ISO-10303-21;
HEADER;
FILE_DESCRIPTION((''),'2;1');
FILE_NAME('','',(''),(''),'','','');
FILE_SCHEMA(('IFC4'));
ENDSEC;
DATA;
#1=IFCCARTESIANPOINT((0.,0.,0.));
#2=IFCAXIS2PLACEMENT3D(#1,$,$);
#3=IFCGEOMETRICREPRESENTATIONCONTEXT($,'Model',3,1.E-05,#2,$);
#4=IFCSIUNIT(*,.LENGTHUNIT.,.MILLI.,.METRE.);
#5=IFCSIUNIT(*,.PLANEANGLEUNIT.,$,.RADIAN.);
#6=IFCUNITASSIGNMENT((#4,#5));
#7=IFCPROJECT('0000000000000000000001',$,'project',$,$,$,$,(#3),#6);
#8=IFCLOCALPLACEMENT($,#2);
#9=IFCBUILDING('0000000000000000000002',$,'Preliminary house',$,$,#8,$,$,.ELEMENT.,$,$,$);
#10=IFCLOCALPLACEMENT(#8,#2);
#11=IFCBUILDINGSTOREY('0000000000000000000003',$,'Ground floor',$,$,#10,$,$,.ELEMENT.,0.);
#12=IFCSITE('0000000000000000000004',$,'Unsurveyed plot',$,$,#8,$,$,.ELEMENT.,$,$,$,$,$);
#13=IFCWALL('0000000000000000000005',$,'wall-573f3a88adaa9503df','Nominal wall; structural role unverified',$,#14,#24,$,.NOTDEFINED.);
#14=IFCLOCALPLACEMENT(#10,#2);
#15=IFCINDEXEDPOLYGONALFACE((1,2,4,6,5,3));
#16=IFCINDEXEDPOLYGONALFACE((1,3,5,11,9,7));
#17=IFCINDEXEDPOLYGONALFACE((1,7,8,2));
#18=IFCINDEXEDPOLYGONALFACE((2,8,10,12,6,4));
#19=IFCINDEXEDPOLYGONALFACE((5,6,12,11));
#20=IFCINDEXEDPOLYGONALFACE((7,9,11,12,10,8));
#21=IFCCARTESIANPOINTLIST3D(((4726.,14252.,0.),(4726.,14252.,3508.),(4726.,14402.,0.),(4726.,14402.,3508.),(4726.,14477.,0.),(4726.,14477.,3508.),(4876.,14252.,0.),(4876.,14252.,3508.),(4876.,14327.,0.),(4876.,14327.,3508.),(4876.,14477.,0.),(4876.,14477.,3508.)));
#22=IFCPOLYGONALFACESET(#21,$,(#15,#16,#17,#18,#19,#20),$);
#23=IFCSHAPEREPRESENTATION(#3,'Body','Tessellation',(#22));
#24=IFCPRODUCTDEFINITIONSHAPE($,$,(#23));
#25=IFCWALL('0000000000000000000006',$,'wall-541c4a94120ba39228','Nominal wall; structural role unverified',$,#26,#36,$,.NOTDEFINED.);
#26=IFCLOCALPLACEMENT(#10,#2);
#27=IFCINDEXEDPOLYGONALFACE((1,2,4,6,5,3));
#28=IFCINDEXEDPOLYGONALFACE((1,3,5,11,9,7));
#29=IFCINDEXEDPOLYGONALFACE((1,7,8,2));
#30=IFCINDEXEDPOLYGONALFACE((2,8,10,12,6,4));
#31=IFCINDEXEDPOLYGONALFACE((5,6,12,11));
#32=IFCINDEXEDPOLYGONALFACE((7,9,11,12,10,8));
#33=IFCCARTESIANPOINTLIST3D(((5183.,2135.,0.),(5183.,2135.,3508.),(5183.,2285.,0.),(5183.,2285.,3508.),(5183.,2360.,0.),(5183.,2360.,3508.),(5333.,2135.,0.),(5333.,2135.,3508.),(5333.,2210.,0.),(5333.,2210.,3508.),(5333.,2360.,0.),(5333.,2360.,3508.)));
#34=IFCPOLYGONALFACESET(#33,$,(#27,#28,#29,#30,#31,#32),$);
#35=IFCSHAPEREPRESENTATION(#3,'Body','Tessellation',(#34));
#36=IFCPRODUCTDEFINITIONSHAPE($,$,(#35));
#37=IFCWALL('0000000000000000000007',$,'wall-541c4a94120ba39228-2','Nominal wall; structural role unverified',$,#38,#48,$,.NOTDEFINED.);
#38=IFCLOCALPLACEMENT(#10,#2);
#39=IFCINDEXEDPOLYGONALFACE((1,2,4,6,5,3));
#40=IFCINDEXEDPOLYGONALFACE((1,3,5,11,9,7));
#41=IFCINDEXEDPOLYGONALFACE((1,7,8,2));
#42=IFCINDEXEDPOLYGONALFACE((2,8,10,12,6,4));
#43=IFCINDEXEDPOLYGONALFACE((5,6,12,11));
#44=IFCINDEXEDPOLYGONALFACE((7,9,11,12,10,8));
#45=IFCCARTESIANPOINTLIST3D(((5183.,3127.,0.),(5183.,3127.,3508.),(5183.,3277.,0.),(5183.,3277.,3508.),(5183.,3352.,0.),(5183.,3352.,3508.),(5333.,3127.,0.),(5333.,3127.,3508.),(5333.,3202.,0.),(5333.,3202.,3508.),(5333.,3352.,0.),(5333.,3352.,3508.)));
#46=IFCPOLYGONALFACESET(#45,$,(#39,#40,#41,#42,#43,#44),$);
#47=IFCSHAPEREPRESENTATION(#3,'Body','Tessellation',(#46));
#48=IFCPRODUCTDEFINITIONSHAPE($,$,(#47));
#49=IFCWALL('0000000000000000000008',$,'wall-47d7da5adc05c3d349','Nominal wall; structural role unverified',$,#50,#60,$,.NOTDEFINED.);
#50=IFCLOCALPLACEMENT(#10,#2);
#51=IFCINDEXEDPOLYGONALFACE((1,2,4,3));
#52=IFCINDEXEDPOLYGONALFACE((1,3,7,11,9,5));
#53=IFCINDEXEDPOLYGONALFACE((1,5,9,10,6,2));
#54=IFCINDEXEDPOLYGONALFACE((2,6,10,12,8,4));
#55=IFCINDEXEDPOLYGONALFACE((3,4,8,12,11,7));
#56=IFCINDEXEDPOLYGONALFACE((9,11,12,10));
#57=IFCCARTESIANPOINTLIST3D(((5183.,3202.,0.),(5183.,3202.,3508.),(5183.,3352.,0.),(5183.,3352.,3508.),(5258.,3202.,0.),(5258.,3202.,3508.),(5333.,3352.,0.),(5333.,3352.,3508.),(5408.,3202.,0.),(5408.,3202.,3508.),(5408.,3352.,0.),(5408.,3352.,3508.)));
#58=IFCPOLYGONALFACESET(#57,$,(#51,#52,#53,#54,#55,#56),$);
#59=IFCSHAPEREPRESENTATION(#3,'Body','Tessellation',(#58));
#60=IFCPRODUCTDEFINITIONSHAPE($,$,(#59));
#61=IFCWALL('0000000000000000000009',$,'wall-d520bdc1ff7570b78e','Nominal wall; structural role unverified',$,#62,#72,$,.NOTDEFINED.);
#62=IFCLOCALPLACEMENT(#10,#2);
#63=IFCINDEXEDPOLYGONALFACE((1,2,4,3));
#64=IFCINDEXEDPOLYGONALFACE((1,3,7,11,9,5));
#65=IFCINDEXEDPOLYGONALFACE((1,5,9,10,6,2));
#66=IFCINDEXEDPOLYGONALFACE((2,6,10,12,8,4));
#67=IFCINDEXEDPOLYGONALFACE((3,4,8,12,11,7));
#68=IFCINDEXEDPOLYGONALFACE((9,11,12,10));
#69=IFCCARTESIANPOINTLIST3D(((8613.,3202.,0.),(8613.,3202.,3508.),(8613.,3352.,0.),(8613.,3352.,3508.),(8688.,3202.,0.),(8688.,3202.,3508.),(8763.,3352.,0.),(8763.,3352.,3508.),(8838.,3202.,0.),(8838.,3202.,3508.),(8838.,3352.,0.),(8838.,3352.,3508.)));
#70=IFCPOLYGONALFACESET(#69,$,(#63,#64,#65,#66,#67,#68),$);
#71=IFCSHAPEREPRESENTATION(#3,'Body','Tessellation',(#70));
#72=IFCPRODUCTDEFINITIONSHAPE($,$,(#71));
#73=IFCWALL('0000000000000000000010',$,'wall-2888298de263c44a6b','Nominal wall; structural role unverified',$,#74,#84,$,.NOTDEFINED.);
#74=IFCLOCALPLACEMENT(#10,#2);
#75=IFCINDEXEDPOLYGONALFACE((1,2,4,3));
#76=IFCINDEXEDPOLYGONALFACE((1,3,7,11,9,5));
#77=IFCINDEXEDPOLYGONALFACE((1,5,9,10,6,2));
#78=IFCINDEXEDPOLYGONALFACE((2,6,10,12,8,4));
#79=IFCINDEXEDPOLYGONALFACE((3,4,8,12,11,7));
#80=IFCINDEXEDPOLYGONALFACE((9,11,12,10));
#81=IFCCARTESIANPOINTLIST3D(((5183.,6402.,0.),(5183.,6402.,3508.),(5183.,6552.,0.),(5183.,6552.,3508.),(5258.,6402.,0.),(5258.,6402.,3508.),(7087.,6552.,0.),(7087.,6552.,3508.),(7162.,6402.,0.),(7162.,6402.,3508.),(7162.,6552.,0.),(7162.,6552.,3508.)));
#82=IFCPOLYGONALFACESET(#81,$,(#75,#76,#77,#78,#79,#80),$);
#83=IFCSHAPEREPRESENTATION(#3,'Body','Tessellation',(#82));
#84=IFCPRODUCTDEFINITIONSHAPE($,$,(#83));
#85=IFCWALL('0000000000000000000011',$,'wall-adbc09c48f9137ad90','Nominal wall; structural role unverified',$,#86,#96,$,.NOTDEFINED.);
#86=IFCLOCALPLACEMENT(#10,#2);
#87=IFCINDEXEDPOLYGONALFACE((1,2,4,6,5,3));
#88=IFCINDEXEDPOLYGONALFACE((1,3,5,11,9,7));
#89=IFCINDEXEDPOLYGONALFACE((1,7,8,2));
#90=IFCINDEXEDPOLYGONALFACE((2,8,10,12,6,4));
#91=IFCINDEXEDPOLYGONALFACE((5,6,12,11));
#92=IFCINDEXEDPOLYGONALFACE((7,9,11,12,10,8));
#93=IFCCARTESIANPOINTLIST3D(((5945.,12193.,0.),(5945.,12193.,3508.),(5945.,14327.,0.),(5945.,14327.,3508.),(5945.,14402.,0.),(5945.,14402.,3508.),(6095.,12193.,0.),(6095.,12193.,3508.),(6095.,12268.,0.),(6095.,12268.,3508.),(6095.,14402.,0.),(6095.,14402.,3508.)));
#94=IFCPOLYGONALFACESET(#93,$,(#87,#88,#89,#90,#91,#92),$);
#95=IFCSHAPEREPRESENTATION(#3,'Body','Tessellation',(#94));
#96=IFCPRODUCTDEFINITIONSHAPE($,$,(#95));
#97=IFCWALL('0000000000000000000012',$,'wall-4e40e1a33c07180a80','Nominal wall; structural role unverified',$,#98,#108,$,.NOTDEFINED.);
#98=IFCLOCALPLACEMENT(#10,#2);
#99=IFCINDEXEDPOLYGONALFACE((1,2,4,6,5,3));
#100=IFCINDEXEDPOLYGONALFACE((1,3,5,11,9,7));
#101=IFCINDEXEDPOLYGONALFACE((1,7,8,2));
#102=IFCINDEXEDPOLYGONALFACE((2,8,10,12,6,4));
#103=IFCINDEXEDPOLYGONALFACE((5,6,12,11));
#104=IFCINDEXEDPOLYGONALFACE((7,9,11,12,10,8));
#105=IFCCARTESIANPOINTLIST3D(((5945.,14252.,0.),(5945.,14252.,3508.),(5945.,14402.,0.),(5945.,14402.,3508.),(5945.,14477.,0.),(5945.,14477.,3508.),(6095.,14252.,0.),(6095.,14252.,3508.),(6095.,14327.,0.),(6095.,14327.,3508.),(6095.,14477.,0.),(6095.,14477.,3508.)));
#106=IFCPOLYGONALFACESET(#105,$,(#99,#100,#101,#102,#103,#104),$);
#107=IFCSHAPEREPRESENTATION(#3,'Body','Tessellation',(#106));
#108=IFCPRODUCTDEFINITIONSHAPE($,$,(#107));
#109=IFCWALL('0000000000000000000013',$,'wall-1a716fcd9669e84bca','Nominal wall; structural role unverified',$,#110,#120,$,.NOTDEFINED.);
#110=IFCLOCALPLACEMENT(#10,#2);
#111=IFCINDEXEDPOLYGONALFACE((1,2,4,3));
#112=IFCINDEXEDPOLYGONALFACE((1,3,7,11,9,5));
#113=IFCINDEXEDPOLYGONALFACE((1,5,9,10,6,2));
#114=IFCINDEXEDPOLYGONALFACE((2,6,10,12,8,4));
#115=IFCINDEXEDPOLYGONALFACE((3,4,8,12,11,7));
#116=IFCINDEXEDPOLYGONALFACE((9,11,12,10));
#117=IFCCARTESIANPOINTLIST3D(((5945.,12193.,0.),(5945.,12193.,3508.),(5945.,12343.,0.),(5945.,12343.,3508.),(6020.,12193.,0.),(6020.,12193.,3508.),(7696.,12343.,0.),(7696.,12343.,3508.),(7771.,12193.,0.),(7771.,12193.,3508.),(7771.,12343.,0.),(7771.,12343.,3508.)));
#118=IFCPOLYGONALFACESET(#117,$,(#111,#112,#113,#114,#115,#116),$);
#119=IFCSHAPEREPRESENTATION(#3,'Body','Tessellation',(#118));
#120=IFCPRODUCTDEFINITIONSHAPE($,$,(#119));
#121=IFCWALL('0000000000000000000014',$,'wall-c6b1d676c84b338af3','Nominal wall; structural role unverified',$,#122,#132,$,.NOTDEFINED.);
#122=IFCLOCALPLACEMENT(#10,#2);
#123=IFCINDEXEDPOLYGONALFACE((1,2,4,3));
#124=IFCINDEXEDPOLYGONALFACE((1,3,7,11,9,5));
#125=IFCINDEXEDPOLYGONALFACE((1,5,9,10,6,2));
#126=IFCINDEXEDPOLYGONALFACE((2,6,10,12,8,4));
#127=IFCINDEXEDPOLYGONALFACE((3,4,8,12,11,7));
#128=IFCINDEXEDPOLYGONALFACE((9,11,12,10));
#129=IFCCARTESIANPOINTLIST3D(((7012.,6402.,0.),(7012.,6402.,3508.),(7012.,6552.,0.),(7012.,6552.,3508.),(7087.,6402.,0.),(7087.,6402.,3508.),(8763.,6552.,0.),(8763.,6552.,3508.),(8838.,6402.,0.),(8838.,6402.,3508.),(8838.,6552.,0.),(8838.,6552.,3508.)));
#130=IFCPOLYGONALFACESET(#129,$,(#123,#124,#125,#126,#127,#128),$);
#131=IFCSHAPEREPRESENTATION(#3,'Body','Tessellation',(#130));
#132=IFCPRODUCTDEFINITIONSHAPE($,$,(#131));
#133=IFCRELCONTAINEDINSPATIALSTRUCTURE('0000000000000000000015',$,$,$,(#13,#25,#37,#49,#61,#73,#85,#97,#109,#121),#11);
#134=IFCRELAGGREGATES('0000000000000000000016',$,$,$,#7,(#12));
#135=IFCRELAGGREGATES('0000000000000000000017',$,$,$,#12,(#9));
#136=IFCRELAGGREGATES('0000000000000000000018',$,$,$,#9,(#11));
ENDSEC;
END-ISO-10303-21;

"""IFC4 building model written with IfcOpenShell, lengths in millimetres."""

from ifc_helpers import new_model, si_unit, origin, place, context, project, spatial, polyline, outline, extrude, element, save


model = new_model("IFC4")

# Units and contexts
model_context = context("Model", 3, precision=1e-05, world=origin())
ifc_project = project(units=[si_unit("LENGTHUNIT", "METRE", prefix="MILLI"), si_unit("PLANEANGLEUNIT", "RADIAN")], contexts=[model_context])

# Site, building, storey
placement_1 = place(None, origin())
site = spatial("IfcSite", under=ifc_project, at=placement_1, Name="Unsurveyed plot", CompositionType="ELEMENT")
building = spatial("IfcBuilding", under=site, at=placement_1, Name="Preliminary house", CompositionType="ELEMENT")
placement_2 = place(placement_1, origin())
storey = spatial("IfcBuildingStorey", under=building, at=placement_2, Name="Ground floor", CompositionType="ELEMENT", Elevation=0.0)

# Walls
element("IfcWall", 1, at=placement_2, inside=storey, Name="wall-573f3a88adaa9503df", Description="Nominal wall; structural role unverified", PredefinedType="NOTDEFINED", context=model_context, shape_type="SweptSolid", body=[
    extrude(outline(polyline([(4726.0, 14402.0), (4726.0, 14477.0), (4876.0, 14477.0), (4876.0, 14327.0), (4876.0, 14252.0), (4726.0, 14252.0), (4726.0, 14402.0)])), origin(), (0.0, 0.0, 1.0), 3508.0),
])
element("IfcWall", 2, at=placement_2, inside=storey, Name="wall-541c4a94120ba39228", Description="Nominal wall; structural role unverified", PredefinedType="NOTDEFINED", context=model_context, shape_type="SweptSolid", body=[
    extrude(outline(polyline([(5183.0, 2285.0), (5183.0, 2360.0), (5333.0, 2360.0), (5333.0, 2210.0), (5333.0, 2135.0), (5183.0, 2135.0), (5183.0, 2285.0)])), origin(), (0.0, 0.0, 1.0), 3508.0),
])

# Wall
element("IfcWall", 3, at=placement_2, inside=storey, Name="wall-541c4a94120ba39228-2", Description="Nominal wall; structural role unverified", PredefinedType="NOTDEFINED", context=model_context, shape_type="SweptSolid", body=[
    extrude(outline(polyline([(5183.0, 3277.0), (5183.0, 3352.0), (5333.0, 3352.0), (5333.0, 3202.0), (5333.0, 3127.0), (5183.0, 3127.0), (5183.0, 3277.0)])), origin(), (0.0, 0.0, 1.0), 3508.0),
])

# Wall
element("IfcWall", 4, at=placement_2, inside=storey, Name="wall-47d7da5adc05c3d349", Description="Nominal wall; structural role unverified", PredefinedType="NOTDEFINED", context=model_context, shape_type="SweptSolid", body=[
    extrude(outline(polyline([(5333.0, 3352.0), (5408.0, 3352.0), (5408.0, 3202.0), (5258.0, 3202.0), (5183.0, 3202.0), (5183.0, 3352.0), (5333.0, 3352.0)])), origin(), (0.0, 0.0, 1.0), 3508.0),
])

# Walls
element("IfcWall", 5, at=placement_2, inside=storey, Name="wall-d520bdc1ff7570b78e", Description="Nominal wall; structural role unverified", PredefinedType="NOTDEFINED", context=model_context, shape_type="SweptSolid", body=[
    extrude(outline(polyline([(8763.0, 3352.0), (8838.0, 3352.0), (8838.0, 3202.0), (8688.0, 3202.0), (8613.0, 3202.0), (8613.0, 3352.0), (8763.0, 3352.0)])), origin(), (0.0, 0.0, 1.0), 3508.0),
])
element("IfcWall", 6, at=placement_2, inside=storey, Name="wall-2888298de263c44a6b", Description="Nominal wall; structural role unverified", PredefinedType="NOTDEFINED", context=model_context, shape_type="SweptSolid", body=[
    extrude(outline(polyline([(7087.0, 6552.0), (7162.0, 6552.0), (7162.0, 6402.0), (5258.0, 6402.0), (5183.0, 6402.0), (5183.0, 6552.0), (7087.0, 6552.0)])), origin(), (0.0, 0.0, 1.0), 3508.0),
])
element("IfcWall", 7, at=placement_2, inside=storey, Name="wall-adbc09c48f9137ad90", Description="Nominal wall; structural role unverified", PredefinedType="NOTDEFINED", context=model_context, shape_type="SweptSolid", body=[
    extrude(outline(polyline([(5945.0, 14327.0), (5945.0, 14402.0), (6095.0, 14402.0), (6095.0, 12268.0), (6095.0, 12193.0), (5945.0, 12193.0), (5945.0, 14327.0)])), origin(), (0.0, 0.0, 1.0), 3508.0),
])
element("IfcWall", 8, at=placement_2, inside=storey, Name="wall-4e40e1a33c07180a80", Description="Nominal wall; structural role unverified", PredefinedType="NOTDEFINED", context=model_context, shape_type="SweptSolid", body=[
    extrude(outline(polyline([(5945.0, 14402.0), (5945.0, 14477.0), (6095.0, 14477.0), (6095.0, 14327.0), (6095.0, 14252.0), (5945.0, 14252.0), (5945.0, 14402.0)])), origin(), (0.0, 0.0, 1.0), 3508.0),
])
element("IfcWall", 9, at=placement_2, inside=storey, Name="wall-1a716fcd9669e84bca", Description="Nominal wall; structural role unverified", PredefinedType="NOTDEFINED", context=model_context, shape_type="SweptSolid", body=[
    extrude(outline(polyline([(7696.0, 12343.0), (7771.0, 12343.0), (7771.0, 12193.0), (6020.0, 12193.0), (5945.0, 12193.0), (5945.0, 12343.0), (7696.0, 12343.0)])), origin(), (0.0, 0.0, 1.0), 3508.0),
])

# Wall
element("IfcWall", 10, at=placement_2, inside=storey, Name="wall-c6b1d676c84b338af3", Description="Nominal wall; structural role unverified", PredefinedType="NOTDEFINED", context=model_context, shape_type="SweptSolid", body=[
    extrude(outline(polyline([(8763.0, 6552.0), (8838.0, 6552.0), (8838.0, 6402.0), (7087.0, 6402.0), (7012.0, 6402.0), (7012.0, 6552.0), (8763.0, 6552.0)])), origin(), (0.0, 0.0, 1.0), 3508.0),
])

save(model, "model.ifc")
